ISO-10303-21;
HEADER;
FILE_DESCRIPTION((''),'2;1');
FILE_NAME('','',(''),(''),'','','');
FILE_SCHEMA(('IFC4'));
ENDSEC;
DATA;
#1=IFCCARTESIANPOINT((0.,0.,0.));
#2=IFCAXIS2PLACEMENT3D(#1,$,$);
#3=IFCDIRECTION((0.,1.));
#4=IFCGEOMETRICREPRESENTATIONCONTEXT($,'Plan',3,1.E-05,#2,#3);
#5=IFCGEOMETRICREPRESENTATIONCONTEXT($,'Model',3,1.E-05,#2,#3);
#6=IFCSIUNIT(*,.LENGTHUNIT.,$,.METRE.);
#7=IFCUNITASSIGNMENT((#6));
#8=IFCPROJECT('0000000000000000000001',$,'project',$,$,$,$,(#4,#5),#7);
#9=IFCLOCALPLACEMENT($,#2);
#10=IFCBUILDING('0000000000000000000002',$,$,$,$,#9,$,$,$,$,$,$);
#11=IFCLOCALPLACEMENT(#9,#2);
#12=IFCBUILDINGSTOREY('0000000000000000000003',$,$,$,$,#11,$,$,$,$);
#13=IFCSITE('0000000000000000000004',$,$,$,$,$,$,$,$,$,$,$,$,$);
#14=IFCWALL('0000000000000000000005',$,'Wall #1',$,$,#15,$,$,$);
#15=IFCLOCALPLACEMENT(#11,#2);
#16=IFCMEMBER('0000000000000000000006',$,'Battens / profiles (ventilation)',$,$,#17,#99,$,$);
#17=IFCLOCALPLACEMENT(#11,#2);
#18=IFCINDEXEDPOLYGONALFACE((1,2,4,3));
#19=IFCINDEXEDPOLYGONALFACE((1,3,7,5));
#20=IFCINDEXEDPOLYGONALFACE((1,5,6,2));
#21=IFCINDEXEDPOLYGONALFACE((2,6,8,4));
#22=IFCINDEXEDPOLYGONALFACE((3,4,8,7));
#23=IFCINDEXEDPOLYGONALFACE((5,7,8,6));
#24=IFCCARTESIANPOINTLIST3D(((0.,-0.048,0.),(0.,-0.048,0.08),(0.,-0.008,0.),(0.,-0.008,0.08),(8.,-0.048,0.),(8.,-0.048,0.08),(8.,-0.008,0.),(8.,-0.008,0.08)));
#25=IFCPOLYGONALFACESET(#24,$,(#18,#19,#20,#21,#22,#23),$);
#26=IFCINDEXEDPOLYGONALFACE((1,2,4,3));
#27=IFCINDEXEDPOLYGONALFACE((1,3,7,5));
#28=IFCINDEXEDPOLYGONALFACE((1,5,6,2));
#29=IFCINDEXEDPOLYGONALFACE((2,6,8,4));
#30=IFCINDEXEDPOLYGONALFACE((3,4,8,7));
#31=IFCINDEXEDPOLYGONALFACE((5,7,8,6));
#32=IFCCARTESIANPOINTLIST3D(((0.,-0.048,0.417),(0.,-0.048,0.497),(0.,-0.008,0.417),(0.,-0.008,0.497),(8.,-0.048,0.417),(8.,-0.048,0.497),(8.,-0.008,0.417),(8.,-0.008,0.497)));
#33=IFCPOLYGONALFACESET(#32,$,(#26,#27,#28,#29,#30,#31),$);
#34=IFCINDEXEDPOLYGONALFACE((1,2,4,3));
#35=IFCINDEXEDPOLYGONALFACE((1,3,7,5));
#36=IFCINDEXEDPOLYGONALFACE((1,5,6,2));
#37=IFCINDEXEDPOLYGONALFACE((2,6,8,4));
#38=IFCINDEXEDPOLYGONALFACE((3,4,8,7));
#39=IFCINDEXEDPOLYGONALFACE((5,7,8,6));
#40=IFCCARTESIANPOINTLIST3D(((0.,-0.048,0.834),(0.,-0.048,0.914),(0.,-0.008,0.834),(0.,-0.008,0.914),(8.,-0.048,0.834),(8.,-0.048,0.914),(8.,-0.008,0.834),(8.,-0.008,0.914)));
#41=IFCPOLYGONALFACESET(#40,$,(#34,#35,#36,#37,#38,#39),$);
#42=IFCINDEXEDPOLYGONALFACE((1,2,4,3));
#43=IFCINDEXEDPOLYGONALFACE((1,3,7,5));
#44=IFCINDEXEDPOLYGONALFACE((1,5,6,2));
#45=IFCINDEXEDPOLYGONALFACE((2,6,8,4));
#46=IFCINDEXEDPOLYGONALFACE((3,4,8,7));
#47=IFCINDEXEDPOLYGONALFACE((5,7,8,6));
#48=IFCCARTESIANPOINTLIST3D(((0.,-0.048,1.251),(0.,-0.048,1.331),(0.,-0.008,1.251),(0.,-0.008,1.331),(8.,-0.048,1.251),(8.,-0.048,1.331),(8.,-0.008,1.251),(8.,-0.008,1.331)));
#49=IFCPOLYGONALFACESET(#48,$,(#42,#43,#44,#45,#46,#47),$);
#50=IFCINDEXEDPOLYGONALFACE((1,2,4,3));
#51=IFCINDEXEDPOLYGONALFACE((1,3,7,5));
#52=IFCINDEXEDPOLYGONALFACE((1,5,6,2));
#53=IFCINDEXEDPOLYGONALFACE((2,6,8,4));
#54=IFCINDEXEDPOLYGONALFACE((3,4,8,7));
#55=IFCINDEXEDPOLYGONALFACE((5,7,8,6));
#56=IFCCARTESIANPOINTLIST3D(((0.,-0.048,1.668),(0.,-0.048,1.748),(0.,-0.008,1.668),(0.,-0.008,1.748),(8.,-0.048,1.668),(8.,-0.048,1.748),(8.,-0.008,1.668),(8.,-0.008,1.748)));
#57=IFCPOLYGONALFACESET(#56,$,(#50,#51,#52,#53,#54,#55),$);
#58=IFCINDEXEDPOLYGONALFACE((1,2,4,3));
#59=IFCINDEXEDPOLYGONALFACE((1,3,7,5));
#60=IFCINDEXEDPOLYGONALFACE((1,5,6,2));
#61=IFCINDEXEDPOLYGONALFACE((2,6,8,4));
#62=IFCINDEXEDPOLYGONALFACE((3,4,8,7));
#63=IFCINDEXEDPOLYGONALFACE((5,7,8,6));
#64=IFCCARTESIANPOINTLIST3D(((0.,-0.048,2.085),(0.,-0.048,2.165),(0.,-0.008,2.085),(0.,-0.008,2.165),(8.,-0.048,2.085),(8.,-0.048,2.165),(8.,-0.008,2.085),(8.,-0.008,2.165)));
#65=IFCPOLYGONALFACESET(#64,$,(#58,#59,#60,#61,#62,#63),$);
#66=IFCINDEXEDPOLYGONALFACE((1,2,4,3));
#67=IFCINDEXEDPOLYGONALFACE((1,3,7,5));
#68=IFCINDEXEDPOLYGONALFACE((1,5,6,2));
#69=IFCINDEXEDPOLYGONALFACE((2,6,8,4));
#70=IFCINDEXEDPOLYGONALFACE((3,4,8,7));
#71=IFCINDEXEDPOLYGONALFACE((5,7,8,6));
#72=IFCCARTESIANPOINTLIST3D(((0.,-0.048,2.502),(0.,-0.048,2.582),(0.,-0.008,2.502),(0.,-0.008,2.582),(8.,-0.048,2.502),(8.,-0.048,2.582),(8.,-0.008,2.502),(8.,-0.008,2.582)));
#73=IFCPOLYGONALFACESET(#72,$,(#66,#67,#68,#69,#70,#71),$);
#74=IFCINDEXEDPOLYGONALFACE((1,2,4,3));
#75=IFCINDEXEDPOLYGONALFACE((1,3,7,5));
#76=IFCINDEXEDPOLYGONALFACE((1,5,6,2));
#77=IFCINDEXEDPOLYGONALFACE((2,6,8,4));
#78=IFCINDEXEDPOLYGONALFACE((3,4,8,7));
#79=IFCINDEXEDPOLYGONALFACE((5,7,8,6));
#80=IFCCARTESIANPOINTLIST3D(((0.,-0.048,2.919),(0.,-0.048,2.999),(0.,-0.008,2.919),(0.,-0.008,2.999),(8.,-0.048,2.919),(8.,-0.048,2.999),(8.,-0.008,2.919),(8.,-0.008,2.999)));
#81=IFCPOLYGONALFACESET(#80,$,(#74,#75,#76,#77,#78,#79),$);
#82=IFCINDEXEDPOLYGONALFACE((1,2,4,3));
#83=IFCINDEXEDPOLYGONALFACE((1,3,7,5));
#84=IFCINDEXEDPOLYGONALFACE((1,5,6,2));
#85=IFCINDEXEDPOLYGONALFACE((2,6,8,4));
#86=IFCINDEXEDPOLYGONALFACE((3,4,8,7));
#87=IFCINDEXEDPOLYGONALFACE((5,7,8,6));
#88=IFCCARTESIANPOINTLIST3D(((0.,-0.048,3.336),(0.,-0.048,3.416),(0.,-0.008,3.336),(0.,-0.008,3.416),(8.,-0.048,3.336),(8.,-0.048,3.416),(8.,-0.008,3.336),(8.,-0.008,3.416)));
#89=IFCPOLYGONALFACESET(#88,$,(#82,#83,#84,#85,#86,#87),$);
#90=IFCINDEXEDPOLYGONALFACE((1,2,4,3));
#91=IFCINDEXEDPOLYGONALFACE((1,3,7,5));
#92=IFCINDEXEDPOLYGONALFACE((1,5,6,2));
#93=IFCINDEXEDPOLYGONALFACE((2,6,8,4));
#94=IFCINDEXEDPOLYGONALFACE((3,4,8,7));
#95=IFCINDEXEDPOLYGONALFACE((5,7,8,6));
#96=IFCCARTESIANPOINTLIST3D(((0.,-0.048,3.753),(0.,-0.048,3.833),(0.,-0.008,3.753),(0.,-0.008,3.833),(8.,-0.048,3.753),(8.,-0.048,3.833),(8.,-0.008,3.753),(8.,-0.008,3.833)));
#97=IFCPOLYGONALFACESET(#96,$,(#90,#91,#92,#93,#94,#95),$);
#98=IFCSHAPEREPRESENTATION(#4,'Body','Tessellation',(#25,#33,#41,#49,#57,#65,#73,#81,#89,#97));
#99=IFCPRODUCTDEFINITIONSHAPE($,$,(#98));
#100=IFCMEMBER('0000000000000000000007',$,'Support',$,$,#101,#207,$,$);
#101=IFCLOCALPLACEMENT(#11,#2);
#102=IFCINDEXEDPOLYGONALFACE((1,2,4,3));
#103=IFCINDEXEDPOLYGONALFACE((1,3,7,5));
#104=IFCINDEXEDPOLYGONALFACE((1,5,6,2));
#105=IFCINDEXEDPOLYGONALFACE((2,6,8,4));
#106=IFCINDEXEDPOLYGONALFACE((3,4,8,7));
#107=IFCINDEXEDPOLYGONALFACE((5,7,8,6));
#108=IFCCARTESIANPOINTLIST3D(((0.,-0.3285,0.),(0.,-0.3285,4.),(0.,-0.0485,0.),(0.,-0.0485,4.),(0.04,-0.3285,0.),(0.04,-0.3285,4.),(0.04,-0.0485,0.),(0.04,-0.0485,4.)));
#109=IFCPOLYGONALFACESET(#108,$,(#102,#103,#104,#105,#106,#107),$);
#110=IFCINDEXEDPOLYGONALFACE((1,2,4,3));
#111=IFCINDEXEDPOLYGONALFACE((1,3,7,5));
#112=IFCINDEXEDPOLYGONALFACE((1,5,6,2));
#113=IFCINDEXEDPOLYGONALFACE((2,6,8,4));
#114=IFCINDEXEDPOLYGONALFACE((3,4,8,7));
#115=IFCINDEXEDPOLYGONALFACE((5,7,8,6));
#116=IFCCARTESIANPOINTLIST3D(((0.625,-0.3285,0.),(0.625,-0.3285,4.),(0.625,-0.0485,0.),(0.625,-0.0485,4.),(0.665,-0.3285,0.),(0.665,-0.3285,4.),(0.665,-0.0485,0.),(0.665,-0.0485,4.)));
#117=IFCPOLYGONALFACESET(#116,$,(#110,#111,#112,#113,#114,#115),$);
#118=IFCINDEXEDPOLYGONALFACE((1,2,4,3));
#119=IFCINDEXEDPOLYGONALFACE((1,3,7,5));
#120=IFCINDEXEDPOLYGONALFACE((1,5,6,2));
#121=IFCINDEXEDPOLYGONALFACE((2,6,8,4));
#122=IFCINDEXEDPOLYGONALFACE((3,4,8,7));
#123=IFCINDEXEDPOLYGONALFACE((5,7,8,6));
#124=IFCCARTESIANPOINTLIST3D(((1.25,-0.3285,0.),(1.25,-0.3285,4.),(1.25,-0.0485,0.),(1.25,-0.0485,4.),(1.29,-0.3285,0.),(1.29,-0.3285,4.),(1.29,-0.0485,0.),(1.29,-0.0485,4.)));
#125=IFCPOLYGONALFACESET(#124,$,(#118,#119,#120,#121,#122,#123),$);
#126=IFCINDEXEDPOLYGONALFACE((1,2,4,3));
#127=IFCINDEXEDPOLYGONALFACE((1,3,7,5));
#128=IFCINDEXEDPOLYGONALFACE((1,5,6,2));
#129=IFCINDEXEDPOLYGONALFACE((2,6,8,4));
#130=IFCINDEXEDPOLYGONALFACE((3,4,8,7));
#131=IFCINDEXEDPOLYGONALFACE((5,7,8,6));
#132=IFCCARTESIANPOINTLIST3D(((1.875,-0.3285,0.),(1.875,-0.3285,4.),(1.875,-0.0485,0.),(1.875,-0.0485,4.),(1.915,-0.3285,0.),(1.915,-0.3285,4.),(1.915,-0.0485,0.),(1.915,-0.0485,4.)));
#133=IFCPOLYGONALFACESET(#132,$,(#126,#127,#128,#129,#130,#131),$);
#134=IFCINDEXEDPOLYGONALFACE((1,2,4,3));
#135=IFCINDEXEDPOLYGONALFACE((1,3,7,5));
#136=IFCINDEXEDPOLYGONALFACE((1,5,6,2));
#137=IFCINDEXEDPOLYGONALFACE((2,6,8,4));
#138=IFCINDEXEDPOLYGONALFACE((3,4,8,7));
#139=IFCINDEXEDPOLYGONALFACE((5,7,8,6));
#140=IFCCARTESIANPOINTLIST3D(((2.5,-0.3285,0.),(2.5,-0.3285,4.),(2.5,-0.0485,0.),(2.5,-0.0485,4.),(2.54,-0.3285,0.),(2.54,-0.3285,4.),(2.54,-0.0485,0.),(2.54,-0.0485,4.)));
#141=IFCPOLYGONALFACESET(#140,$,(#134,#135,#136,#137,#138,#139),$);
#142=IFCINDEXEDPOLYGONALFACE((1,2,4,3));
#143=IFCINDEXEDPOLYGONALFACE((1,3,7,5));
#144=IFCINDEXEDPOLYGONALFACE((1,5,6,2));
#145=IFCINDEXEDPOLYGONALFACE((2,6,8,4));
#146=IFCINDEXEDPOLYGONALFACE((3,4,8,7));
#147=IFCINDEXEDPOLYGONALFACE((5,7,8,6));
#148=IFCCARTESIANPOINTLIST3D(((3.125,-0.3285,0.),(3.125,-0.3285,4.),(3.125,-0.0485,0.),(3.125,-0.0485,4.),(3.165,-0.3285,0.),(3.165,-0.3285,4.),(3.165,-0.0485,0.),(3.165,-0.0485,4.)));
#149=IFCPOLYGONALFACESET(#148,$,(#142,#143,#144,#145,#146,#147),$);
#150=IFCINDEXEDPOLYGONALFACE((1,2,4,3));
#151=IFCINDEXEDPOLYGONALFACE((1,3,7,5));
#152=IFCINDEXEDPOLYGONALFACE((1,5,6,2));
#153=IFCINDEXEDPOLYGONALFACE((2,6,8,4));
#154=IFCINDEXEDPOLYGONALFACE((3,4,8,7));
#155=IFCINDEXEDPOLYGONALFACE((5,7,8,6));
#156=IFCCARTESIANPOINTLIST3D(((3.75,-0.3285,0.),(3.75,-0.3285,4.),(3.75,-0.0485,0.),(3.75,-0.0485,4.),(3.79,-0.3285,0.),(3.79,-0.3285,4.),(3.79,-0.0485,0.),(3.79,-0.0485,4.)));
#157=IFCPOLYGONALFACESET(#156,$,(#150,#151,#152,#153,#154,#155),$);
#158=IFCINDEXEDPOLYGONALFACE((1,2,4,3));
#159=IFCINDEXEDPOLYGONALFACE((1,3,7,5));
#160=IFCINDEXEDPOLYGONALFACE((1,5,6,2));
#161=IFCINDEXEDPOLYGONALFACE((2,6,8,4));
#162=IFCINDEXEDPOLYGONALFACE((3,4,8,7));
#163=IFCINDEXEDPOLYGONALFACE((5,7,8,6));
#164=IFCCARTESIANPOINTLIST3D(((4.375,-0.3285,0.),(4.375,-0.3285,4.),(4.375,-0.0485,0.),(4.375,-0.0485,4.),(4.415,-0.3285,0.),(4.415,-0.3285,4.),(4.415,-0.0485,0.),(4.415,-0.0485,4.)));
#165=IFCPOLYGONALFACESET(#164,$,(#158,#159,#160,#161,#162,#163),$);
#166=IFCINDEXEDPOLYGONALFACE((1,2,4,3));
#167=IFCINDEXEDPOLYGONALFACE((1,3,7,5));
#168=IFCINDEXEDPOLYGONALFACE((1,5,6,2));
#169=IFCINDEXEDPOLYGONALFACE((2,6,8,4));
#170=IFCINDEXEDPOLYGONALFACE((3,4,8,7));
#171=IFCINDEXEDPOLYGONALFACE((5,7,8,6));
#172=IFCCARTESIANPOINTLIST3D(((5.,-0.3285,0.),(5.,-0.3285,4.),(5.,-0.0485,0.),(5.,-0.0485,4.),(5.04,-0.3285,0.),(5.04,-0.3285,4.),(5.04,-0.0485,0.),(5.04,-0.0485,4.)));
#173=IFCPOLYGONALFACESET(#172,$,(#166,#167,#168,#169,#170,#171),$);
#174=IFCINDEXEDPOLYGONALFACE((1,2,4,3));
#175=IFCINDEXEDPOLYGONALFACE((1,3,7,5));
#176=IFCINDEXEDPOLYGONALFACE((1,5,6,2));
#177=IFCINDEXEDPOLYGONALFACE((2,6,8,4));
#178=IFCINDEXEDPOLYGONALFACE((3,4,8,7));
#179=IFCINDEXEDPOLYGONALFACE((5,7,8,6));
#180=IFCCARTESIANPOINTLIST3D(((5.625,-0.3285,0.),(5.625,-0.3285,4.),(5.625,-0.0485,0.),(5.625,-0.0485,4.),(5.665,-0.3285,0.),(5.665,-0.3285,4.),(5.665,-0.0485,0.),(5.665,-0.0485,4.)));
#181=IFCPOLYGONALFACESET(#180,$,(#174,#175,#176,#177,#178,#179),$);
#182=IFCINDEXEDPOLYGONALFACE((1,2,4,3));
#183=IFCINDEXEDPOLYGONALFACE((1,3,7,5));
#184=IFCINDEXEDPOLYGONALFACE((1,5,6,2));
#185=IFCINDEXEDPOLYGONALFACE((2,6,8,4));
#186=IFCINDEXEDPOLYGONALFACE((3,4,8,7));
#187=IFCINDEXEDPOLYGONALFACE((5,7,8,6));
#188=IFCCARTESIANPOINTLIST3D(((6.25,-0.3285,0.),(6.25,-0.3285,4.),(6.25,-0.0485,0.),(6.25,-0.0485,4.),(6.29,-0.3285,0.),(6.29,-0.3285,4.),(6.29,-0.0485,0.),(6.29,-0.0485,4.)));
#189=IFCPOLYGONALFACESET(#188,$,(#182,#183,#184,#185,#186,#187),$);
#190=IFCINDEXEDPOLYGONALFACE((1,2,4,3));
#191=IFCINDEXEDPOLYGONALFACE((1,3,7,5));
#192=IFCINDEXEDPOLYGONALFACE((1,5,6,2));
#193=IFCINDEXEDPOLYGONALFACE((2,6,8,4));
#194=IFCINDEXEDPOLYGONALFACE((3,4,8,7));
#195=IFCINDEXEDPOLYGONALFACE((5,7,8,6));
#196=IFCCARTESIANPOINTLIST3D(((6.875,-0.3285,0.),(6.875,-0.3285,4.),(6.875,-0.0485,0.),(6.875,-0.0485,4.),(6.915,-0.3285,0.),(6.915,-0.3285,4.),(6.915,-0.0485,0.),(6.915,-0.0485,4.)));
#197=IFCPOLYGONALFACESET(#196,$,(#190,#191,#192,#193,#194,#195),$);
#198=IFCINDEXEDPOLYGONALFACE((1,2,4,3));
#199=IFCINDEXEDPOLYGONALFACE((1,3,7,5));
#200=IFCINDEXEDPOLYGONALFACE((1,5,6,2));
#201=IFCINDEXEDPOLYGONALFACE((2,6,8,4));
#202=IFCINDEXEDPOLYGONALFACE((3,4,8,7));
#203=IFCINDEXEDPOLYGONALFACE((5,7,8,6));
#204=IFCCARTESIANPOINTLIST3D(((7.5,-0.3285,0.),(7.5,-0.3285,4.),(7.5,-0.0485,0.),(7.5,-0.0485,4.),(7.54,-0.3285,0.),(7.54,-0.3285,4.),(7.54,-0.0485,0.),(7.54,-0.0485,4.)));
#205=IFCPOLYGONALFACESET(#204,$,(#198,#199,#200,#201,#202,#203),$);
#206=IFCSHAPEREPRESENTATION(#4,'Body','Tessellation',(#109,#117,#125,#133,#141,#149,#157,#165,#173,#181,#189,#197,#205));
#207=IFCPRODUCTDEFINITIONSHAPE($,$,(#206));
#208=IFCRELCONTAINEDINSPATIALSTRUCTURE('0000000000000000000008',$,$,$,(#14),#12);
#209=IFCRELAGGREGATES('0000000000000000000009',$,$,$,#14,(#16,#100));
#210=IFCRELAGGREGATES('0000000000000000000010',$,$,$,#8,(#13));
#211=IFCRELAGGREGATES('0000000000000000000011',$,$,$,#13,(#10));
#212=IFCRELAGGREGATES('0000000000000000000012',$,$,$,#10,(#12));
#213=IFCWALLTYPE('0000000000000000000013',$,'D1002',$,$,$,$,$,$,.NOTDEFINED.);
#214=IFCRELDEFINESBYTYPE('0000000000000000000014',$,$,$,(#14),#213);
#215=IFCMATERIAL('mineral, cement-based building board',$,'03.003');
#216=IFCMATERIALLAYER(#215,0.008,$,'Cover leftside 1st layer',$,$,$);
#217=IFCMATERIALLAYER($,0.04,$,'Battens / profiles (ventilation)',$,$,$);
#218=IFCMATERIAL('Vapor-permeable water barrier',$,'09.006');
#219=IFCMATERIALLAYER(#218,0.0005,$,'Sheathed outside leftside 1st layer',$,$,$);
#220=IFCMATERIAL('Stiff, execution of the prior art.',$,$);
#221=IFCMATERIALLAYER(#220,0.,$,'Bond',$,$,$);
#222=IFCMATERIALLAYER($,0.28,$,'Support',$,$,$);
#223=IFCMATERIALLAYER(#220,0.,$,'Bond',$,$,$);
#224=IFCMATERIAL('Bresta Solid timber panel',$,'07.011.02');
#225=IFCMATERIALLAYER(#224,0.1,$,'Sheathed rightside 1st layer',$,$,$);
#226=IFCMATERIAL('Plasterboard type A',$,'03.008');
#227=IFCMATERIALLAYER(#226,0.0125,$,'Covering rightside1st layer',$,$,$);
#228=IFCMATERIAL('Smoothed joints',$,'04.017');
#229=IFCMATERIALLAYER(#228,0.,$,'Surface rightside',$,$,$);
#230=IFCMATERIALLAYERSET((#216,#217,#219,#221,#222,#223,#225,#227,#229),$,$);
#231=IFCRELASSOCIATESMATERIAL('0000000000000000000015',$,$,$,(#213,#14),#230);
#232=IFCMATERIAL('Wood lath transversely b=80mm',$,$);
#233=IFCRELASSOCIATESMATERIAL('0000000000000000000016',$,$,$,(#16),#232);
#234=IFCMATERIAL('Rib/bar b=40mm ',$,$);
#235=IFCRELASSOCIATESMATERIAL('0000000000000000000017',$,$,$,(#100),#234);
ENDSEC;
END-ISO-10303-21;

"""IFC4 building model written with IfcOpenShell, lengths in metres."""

from ifc_helpers import new_model, si_unit, direction, frame, frame_2d, origin, place, context, project, spatial, rectangle, extrude, material, layer, layer_set, type_object, element, aggregate, save


model = new_model("IFC4")

# Units and contexts
plan_context = context("Plan", 3, precision=1e-05, world=origin(), true_north=direction((0.0, 1.0)))
model_context = context("Model", 3, precision=1e-05, world=origin(), true_north=direction((0.0, 1.0)))
ifc_project = project(units=[si_unit("LENGTHUNIT", "METRE")], contexts=[plan_context, model_context])

# Site, building, storey
site = spatial("IfcSite", under=ifc_project)
building_placement = place(None, origin())
building = spatial("IfcBuilding", under=site, at=building_placement)
storey_placement = place(building_placement, origin())
storey = spatial("IfcBuildingStorey", under=building, at=storey_placement)

# Wall, members
ifc_material_1 = material(Name="mineral, cement-based building board", Category="03.003")
ifc_layer_1 = layer(ifc_material_1, 0.008, Name="Cover leftside 1st layer")
ifc_layer_2 = layer(None, 0.04, Name="Battens / profiles (ventilation)")
ifc_material_2 = material(Name="Vapor-permeable water barrier", Category="09.006")
ifc_layer_3 = layer(ifc_material_2, 0.0005, Name="Sheathed outside leftside 1st layer")
ifc_material_3 = material(Name="Stiff, execution of the prior art.")
ifc_layer_4 = layer(ifc_material_3, 0.0, Name="Bond")
ifc_layer_5 = layer(None, 0.28, Name="Support")
ifc_layer_6 = layer(ifc_material_3, 0.0, Name="Bond")
ifc_material_4 = material(Name="Bresta Solid timber panel", Category="07.011.02")
ifc_layer_7 = layer(ifc_material_4, 0.1, Name="Sheathed rightside 1st layer")
ifc_material_5 = material(Name="Plasterboard type A", Category="03.008")
ifc_layer_8 = layer(ifc_material_5, 0.0125, Name="Covering rightside1st layer")
ifc_material_6 = material(Name="Smoothed joints", Category="04.017")
ifc_layer_9 = layer(ifc_material_6, 0.0, Name="Surface rightside")
ifc_layer_set = layer_set([ifc_layer_1, ifc_layer_2, ifc_layer_3, ifc_layer_4, ifc_layer_5, ifc_layer_6, ifc_layer_7, ifc_layer_8, ifc_layer_9])
wall_type = type_object("IfcWallType", Name="D1002", PredefinedType="NOTDEFINED", material=ifc_layer_set)
wall_placement = place(None, frame((0.0, 0.0, 0.0), z_axis=(0.0, -1.0, 0.0), x_axis=(1.0, 0.0, 0.0)))
wall = element("IfcWall", 1, at=wall_placement, inside=storey, type_object=wall_type, material=ifc_layer_set, Name="Wall #1")
ifc_material_7 = material(Name="Wood lath transversely b=80mm")
member_1_placement = place(wall_placement, origin())
member_1 = element("IfcMember", 2, at=member_1_placement, material=ifc_material_7, Name="Battens / profiles (ventilation)", context=plan_context, shape_type="SweptSolid", body=[
    extrude(rectangle(XDim=0.08, YDim=0.04, at=frame_2d((0.04, 0.02), x_axis=(1.0, 0.0))), frame((0.0, 0.0, 0.008), z_axis=(1.0, 0.0, 0.0), x_axis=(0.0, 1.0, 0.0)), (0.0, 0.0, 1.0), 8.0),
    extrude(rectangle(XDim=0.08, YDim=0.04, at=frame_2d((0.04, 0.02), x_axis=(1.0, 0.0))), frame((0.0, 0.417, 0.008), z_axis=(1.0, 0.0, 0.0), x_axis=(0.0, 1.0, 0.0)), (0.0, 0.0, 1.0), 8.0),
    extrude(rectangle(XDim=0.08, YDim=0.04, at=frame_2d((0.04, 0.02), x_axis=(1.0, 0.0))), frame((0.0, 0.834, 0.008), z_axis=(1.0, 0.0, 0.0), x_axis=(0.0, 1.0, 0.0)), (0.0, 0.0, 1.0), 8.0),
    extrude(rectangle(XDim=0.08, YDim=0.04, at=frame_2d((0.04, 0.02), x_axis=(1.0, 0.0))), frame((0.0, 1.251, 0.008), z_axis=(1.0, 0.0, 0.0), x_axis=(0.0, 1.0, 0.0)), (0.0, 0.0, 1.0), 8.0),
    extrude(rectangle(XDim=0.08, YDim=0.04, at=frame_2d((0.04, 0.02), x_axis=(1.0, 0.0))), frame((0.0, 1.668, 0.008), z_axis=(1.0, 0.0, 0.0), x_axis=(0.0, 1.0, 0.0)), (0.0, 0.0, 1.0), 8.0),
    extrude(rectangle(XDim=0.08, YDim=0.04, at=frame_2d((0.04, 0.02), x_axis=(1.0, 0.0))), frame((0.0, 2.085, 0.008), z_axis=(1.0, 0.0, 0.0), x_axis=(0.0, 1.0, 0.0)), (0.0, 0.0, 1.0), 8.0),
    extrude(rectangle(XDim=0.08, YDim=0.04, at=frame_2d((0.04, 0.02), x_axis=(1.0, 0.0))), frame((0.0, 2.502, 0.008), z_axis=(1.0, 0.0, 0.0), x_axis=(0.0, 1.0, 0.0)), (0.0, 0.0, 1.0), 8.0),
    extrude(rectangle(XDim=0.08, YDim=0.04, at=frame_2d((0.04, 0.02), x_axis=(1.0, 0.0))), frame((0.0, 2.919, 0.008), z_axis=(1.0, 0.0, 0.0), x_axis=(0.0, 1.0, 0.0)), (0.0, 0.0, 1.0), 8.0),
    extrude(rectangle(XDim=0.08, YDim=0.04, at=frame_2d((0.04, 0.02), x_axis=(1.0, 0.0))), frame((0.0, 3.336, 0.008), z_axis=(1.0, 0.0, 0.0), x_axis=(0.0, 1.0, 0.0)), (0.0, 0.0, 1.0), 8.0),
    extrude(rectangle(XDim=0.08, YDim=0.04, at=frame_2d((0.04, 0.02), x_axis=(1.0, 0.0))), frame((0.0, 3.753, 0.008), z_axis=(1.0, 0.0, 0.0), x_axis=(0.0, 1.0, 0.0)), (0.0, 0.0, 1.0), 8.0),
])
ifc_material_8 = material(Name="Rib/bar b=40mm ")
member_2_placement = place(wall_placement, origin())
member_2 = element("IfcMember", 3, at=member_2_placement, material=ifc_material_8, Name="Support", context=plan_context, shape_type="SweptSolid", body=[
    extrude(rectangle(XDim=0.04, YDim=0.28, at=frame_2d((0.02, 0.14), x_axis=(1.0, 0.0))), frame((0.0, 4.0, 0.0485), z_axis=(0.0, -1.0, 0.0), x_axis=(1.0, 0.0, 0.0)), (0.0, 0.0, 1.0), 4.0),
    extrude(rectangle(XDim=0.04, YDim=0.28, at=frame_2d((0.02, 0.14), x_axis=(1.0, 0.0))), frame((0.625, 4.0, 0.0485), z_axis=(0.0, -1.0, 0.0), x_axis=(1.0, 0.0, 0.0)), (0.0, 0.0, 1.0), 4.0),
    extrude(rectangle(XDim=0.04, YDim=0.28, at=frame_2d((0.02, 0.14), x_axis=(1.0, 0.0))), frame((1.25, 4.0, 0.0485), z_axis=(0.0, -1.0, 0.0), x_axis=(1.0, 0.0, 0.0)), (0.0, 0.0, 1.0), 4.0),
    extrude(rectangle(XDim=0.04, YDim=0.28, at=frame_2d((0.02, 0.14), x_axis=(1.0, 0.0))), frame((1.875, 4.0, 0.0485), z_axis=(0.0, -1.0, 0.0), x_axis=(1.0, 0.0, 0.0)), (0.0, 0.0, 1.0), 4.0),
    extrude(rectangle(XDim=0.04, YDim=0.28, at=frame_2d((0.02, 0.14), x_axis=(1.0, 0.0))), frame((2.5, 4.0, 0.0485), z_axis=(0.0, -1.0, 0.0), x_axis=(1.0, 0.0, 0.0)), (0.0, 0.0, 1.0), 4.0),
    extrude(rectangle(XDim=0.04, YDim=0.28, at=frame_2d((0.02, 0.14), x_axis=(1.0, 0.0))), frame((3.125, 4.0, 0.0485), z_axis=(0.0, -1.0, 0.0), x_axis=(1.0, 0.0, 0.0)), (0.0, 0.0, 1.0), 4.0),
    extrude(rectangle(XDim=0.04, YDim=0.28, at=frame_2d((0.02, 0.14), x_axis=(1.0, 0.0))), frame((3.75, 4.0, 0.0485), z_axis=(0.0, -1.0, 0.0), x_axis=(1.0, 0.0, 0.0)), (0.0, 0.0, 1.0), 4.0),
    extrude(rectangle(XDim=0.04, YDim=0.28, at=frame_2d((0.02, 0.14), x_axis=(1.0, 0.0))), frame((4.375, 4.0, 0.0485), z_axis=(0.0, -1.0, 0.0), x_axis=(1.0, 0.0, 0.0)), (0.0, 0.0, 1.0), 4.0),
    extrude(rectangle(XDim=0.04, YDim=0.28, at=frame_2d((0.02, 0.14), x_axis=(1.0, 0.0))), frame((5.0, 4.0, 0.0485), z_axis=(0.0, -1.0, 0.0), x_axis=(1.0, 0.0, 0.0)), (0.0, 0.0, 1.0), 4.0),
    extrude(rectangle(XDim=0.04, YDim=0.28, at=frame_2d((0.02, 0.14), x_axis=(1.0, 0.0))), frame((5.625, 4.0, 0.0485), z_axis=(0.0, -1.0, 0.0), x_axis=(1.0, 0.0, 0.0)), (0.0, 0.0, 1.0), 4.0),
    extrude(rectangle(XDim=0.04, YDim=0.28, at=frame_2d((0.02, 0.14), x_axis=(1.0, 0.0))), frame((6.25, 4.0, 0.0485), z_axis=(0.0, -1.0, 0.0), x_axis=(1.0, 0.0, 0.0)), (0.0, 0.0, 1.0), 4.0),
    extrude(rectangle(XDim=0.04, YDim=0.28, at=frame_2d((0.02, 0.14), x_axis=(1.0, 0.0))), frame((6.875, 4.0, 0.0485), z_axis=(0.0, -1.0, 0.0), x_axis=(1.0, 0.0, 0.0)), (0.0, 0.0, 1.0), 4.0),
    extrude(rectangle(XDim=0.04, YDim=0.28, at=frame_2d((0.02, 0.14), x_axis=(1.0, 0.0))), frame((7.5, 4.0, 0.0485), z_axis=(0.0, -1.0, 0.0), x_axis=(1.0, 0.0, 0.0)), (0.0, 0.0, 1.0), 4.0),
])
aggregate(wall, [member_1, member_2])

save(model, "model.ifc")
